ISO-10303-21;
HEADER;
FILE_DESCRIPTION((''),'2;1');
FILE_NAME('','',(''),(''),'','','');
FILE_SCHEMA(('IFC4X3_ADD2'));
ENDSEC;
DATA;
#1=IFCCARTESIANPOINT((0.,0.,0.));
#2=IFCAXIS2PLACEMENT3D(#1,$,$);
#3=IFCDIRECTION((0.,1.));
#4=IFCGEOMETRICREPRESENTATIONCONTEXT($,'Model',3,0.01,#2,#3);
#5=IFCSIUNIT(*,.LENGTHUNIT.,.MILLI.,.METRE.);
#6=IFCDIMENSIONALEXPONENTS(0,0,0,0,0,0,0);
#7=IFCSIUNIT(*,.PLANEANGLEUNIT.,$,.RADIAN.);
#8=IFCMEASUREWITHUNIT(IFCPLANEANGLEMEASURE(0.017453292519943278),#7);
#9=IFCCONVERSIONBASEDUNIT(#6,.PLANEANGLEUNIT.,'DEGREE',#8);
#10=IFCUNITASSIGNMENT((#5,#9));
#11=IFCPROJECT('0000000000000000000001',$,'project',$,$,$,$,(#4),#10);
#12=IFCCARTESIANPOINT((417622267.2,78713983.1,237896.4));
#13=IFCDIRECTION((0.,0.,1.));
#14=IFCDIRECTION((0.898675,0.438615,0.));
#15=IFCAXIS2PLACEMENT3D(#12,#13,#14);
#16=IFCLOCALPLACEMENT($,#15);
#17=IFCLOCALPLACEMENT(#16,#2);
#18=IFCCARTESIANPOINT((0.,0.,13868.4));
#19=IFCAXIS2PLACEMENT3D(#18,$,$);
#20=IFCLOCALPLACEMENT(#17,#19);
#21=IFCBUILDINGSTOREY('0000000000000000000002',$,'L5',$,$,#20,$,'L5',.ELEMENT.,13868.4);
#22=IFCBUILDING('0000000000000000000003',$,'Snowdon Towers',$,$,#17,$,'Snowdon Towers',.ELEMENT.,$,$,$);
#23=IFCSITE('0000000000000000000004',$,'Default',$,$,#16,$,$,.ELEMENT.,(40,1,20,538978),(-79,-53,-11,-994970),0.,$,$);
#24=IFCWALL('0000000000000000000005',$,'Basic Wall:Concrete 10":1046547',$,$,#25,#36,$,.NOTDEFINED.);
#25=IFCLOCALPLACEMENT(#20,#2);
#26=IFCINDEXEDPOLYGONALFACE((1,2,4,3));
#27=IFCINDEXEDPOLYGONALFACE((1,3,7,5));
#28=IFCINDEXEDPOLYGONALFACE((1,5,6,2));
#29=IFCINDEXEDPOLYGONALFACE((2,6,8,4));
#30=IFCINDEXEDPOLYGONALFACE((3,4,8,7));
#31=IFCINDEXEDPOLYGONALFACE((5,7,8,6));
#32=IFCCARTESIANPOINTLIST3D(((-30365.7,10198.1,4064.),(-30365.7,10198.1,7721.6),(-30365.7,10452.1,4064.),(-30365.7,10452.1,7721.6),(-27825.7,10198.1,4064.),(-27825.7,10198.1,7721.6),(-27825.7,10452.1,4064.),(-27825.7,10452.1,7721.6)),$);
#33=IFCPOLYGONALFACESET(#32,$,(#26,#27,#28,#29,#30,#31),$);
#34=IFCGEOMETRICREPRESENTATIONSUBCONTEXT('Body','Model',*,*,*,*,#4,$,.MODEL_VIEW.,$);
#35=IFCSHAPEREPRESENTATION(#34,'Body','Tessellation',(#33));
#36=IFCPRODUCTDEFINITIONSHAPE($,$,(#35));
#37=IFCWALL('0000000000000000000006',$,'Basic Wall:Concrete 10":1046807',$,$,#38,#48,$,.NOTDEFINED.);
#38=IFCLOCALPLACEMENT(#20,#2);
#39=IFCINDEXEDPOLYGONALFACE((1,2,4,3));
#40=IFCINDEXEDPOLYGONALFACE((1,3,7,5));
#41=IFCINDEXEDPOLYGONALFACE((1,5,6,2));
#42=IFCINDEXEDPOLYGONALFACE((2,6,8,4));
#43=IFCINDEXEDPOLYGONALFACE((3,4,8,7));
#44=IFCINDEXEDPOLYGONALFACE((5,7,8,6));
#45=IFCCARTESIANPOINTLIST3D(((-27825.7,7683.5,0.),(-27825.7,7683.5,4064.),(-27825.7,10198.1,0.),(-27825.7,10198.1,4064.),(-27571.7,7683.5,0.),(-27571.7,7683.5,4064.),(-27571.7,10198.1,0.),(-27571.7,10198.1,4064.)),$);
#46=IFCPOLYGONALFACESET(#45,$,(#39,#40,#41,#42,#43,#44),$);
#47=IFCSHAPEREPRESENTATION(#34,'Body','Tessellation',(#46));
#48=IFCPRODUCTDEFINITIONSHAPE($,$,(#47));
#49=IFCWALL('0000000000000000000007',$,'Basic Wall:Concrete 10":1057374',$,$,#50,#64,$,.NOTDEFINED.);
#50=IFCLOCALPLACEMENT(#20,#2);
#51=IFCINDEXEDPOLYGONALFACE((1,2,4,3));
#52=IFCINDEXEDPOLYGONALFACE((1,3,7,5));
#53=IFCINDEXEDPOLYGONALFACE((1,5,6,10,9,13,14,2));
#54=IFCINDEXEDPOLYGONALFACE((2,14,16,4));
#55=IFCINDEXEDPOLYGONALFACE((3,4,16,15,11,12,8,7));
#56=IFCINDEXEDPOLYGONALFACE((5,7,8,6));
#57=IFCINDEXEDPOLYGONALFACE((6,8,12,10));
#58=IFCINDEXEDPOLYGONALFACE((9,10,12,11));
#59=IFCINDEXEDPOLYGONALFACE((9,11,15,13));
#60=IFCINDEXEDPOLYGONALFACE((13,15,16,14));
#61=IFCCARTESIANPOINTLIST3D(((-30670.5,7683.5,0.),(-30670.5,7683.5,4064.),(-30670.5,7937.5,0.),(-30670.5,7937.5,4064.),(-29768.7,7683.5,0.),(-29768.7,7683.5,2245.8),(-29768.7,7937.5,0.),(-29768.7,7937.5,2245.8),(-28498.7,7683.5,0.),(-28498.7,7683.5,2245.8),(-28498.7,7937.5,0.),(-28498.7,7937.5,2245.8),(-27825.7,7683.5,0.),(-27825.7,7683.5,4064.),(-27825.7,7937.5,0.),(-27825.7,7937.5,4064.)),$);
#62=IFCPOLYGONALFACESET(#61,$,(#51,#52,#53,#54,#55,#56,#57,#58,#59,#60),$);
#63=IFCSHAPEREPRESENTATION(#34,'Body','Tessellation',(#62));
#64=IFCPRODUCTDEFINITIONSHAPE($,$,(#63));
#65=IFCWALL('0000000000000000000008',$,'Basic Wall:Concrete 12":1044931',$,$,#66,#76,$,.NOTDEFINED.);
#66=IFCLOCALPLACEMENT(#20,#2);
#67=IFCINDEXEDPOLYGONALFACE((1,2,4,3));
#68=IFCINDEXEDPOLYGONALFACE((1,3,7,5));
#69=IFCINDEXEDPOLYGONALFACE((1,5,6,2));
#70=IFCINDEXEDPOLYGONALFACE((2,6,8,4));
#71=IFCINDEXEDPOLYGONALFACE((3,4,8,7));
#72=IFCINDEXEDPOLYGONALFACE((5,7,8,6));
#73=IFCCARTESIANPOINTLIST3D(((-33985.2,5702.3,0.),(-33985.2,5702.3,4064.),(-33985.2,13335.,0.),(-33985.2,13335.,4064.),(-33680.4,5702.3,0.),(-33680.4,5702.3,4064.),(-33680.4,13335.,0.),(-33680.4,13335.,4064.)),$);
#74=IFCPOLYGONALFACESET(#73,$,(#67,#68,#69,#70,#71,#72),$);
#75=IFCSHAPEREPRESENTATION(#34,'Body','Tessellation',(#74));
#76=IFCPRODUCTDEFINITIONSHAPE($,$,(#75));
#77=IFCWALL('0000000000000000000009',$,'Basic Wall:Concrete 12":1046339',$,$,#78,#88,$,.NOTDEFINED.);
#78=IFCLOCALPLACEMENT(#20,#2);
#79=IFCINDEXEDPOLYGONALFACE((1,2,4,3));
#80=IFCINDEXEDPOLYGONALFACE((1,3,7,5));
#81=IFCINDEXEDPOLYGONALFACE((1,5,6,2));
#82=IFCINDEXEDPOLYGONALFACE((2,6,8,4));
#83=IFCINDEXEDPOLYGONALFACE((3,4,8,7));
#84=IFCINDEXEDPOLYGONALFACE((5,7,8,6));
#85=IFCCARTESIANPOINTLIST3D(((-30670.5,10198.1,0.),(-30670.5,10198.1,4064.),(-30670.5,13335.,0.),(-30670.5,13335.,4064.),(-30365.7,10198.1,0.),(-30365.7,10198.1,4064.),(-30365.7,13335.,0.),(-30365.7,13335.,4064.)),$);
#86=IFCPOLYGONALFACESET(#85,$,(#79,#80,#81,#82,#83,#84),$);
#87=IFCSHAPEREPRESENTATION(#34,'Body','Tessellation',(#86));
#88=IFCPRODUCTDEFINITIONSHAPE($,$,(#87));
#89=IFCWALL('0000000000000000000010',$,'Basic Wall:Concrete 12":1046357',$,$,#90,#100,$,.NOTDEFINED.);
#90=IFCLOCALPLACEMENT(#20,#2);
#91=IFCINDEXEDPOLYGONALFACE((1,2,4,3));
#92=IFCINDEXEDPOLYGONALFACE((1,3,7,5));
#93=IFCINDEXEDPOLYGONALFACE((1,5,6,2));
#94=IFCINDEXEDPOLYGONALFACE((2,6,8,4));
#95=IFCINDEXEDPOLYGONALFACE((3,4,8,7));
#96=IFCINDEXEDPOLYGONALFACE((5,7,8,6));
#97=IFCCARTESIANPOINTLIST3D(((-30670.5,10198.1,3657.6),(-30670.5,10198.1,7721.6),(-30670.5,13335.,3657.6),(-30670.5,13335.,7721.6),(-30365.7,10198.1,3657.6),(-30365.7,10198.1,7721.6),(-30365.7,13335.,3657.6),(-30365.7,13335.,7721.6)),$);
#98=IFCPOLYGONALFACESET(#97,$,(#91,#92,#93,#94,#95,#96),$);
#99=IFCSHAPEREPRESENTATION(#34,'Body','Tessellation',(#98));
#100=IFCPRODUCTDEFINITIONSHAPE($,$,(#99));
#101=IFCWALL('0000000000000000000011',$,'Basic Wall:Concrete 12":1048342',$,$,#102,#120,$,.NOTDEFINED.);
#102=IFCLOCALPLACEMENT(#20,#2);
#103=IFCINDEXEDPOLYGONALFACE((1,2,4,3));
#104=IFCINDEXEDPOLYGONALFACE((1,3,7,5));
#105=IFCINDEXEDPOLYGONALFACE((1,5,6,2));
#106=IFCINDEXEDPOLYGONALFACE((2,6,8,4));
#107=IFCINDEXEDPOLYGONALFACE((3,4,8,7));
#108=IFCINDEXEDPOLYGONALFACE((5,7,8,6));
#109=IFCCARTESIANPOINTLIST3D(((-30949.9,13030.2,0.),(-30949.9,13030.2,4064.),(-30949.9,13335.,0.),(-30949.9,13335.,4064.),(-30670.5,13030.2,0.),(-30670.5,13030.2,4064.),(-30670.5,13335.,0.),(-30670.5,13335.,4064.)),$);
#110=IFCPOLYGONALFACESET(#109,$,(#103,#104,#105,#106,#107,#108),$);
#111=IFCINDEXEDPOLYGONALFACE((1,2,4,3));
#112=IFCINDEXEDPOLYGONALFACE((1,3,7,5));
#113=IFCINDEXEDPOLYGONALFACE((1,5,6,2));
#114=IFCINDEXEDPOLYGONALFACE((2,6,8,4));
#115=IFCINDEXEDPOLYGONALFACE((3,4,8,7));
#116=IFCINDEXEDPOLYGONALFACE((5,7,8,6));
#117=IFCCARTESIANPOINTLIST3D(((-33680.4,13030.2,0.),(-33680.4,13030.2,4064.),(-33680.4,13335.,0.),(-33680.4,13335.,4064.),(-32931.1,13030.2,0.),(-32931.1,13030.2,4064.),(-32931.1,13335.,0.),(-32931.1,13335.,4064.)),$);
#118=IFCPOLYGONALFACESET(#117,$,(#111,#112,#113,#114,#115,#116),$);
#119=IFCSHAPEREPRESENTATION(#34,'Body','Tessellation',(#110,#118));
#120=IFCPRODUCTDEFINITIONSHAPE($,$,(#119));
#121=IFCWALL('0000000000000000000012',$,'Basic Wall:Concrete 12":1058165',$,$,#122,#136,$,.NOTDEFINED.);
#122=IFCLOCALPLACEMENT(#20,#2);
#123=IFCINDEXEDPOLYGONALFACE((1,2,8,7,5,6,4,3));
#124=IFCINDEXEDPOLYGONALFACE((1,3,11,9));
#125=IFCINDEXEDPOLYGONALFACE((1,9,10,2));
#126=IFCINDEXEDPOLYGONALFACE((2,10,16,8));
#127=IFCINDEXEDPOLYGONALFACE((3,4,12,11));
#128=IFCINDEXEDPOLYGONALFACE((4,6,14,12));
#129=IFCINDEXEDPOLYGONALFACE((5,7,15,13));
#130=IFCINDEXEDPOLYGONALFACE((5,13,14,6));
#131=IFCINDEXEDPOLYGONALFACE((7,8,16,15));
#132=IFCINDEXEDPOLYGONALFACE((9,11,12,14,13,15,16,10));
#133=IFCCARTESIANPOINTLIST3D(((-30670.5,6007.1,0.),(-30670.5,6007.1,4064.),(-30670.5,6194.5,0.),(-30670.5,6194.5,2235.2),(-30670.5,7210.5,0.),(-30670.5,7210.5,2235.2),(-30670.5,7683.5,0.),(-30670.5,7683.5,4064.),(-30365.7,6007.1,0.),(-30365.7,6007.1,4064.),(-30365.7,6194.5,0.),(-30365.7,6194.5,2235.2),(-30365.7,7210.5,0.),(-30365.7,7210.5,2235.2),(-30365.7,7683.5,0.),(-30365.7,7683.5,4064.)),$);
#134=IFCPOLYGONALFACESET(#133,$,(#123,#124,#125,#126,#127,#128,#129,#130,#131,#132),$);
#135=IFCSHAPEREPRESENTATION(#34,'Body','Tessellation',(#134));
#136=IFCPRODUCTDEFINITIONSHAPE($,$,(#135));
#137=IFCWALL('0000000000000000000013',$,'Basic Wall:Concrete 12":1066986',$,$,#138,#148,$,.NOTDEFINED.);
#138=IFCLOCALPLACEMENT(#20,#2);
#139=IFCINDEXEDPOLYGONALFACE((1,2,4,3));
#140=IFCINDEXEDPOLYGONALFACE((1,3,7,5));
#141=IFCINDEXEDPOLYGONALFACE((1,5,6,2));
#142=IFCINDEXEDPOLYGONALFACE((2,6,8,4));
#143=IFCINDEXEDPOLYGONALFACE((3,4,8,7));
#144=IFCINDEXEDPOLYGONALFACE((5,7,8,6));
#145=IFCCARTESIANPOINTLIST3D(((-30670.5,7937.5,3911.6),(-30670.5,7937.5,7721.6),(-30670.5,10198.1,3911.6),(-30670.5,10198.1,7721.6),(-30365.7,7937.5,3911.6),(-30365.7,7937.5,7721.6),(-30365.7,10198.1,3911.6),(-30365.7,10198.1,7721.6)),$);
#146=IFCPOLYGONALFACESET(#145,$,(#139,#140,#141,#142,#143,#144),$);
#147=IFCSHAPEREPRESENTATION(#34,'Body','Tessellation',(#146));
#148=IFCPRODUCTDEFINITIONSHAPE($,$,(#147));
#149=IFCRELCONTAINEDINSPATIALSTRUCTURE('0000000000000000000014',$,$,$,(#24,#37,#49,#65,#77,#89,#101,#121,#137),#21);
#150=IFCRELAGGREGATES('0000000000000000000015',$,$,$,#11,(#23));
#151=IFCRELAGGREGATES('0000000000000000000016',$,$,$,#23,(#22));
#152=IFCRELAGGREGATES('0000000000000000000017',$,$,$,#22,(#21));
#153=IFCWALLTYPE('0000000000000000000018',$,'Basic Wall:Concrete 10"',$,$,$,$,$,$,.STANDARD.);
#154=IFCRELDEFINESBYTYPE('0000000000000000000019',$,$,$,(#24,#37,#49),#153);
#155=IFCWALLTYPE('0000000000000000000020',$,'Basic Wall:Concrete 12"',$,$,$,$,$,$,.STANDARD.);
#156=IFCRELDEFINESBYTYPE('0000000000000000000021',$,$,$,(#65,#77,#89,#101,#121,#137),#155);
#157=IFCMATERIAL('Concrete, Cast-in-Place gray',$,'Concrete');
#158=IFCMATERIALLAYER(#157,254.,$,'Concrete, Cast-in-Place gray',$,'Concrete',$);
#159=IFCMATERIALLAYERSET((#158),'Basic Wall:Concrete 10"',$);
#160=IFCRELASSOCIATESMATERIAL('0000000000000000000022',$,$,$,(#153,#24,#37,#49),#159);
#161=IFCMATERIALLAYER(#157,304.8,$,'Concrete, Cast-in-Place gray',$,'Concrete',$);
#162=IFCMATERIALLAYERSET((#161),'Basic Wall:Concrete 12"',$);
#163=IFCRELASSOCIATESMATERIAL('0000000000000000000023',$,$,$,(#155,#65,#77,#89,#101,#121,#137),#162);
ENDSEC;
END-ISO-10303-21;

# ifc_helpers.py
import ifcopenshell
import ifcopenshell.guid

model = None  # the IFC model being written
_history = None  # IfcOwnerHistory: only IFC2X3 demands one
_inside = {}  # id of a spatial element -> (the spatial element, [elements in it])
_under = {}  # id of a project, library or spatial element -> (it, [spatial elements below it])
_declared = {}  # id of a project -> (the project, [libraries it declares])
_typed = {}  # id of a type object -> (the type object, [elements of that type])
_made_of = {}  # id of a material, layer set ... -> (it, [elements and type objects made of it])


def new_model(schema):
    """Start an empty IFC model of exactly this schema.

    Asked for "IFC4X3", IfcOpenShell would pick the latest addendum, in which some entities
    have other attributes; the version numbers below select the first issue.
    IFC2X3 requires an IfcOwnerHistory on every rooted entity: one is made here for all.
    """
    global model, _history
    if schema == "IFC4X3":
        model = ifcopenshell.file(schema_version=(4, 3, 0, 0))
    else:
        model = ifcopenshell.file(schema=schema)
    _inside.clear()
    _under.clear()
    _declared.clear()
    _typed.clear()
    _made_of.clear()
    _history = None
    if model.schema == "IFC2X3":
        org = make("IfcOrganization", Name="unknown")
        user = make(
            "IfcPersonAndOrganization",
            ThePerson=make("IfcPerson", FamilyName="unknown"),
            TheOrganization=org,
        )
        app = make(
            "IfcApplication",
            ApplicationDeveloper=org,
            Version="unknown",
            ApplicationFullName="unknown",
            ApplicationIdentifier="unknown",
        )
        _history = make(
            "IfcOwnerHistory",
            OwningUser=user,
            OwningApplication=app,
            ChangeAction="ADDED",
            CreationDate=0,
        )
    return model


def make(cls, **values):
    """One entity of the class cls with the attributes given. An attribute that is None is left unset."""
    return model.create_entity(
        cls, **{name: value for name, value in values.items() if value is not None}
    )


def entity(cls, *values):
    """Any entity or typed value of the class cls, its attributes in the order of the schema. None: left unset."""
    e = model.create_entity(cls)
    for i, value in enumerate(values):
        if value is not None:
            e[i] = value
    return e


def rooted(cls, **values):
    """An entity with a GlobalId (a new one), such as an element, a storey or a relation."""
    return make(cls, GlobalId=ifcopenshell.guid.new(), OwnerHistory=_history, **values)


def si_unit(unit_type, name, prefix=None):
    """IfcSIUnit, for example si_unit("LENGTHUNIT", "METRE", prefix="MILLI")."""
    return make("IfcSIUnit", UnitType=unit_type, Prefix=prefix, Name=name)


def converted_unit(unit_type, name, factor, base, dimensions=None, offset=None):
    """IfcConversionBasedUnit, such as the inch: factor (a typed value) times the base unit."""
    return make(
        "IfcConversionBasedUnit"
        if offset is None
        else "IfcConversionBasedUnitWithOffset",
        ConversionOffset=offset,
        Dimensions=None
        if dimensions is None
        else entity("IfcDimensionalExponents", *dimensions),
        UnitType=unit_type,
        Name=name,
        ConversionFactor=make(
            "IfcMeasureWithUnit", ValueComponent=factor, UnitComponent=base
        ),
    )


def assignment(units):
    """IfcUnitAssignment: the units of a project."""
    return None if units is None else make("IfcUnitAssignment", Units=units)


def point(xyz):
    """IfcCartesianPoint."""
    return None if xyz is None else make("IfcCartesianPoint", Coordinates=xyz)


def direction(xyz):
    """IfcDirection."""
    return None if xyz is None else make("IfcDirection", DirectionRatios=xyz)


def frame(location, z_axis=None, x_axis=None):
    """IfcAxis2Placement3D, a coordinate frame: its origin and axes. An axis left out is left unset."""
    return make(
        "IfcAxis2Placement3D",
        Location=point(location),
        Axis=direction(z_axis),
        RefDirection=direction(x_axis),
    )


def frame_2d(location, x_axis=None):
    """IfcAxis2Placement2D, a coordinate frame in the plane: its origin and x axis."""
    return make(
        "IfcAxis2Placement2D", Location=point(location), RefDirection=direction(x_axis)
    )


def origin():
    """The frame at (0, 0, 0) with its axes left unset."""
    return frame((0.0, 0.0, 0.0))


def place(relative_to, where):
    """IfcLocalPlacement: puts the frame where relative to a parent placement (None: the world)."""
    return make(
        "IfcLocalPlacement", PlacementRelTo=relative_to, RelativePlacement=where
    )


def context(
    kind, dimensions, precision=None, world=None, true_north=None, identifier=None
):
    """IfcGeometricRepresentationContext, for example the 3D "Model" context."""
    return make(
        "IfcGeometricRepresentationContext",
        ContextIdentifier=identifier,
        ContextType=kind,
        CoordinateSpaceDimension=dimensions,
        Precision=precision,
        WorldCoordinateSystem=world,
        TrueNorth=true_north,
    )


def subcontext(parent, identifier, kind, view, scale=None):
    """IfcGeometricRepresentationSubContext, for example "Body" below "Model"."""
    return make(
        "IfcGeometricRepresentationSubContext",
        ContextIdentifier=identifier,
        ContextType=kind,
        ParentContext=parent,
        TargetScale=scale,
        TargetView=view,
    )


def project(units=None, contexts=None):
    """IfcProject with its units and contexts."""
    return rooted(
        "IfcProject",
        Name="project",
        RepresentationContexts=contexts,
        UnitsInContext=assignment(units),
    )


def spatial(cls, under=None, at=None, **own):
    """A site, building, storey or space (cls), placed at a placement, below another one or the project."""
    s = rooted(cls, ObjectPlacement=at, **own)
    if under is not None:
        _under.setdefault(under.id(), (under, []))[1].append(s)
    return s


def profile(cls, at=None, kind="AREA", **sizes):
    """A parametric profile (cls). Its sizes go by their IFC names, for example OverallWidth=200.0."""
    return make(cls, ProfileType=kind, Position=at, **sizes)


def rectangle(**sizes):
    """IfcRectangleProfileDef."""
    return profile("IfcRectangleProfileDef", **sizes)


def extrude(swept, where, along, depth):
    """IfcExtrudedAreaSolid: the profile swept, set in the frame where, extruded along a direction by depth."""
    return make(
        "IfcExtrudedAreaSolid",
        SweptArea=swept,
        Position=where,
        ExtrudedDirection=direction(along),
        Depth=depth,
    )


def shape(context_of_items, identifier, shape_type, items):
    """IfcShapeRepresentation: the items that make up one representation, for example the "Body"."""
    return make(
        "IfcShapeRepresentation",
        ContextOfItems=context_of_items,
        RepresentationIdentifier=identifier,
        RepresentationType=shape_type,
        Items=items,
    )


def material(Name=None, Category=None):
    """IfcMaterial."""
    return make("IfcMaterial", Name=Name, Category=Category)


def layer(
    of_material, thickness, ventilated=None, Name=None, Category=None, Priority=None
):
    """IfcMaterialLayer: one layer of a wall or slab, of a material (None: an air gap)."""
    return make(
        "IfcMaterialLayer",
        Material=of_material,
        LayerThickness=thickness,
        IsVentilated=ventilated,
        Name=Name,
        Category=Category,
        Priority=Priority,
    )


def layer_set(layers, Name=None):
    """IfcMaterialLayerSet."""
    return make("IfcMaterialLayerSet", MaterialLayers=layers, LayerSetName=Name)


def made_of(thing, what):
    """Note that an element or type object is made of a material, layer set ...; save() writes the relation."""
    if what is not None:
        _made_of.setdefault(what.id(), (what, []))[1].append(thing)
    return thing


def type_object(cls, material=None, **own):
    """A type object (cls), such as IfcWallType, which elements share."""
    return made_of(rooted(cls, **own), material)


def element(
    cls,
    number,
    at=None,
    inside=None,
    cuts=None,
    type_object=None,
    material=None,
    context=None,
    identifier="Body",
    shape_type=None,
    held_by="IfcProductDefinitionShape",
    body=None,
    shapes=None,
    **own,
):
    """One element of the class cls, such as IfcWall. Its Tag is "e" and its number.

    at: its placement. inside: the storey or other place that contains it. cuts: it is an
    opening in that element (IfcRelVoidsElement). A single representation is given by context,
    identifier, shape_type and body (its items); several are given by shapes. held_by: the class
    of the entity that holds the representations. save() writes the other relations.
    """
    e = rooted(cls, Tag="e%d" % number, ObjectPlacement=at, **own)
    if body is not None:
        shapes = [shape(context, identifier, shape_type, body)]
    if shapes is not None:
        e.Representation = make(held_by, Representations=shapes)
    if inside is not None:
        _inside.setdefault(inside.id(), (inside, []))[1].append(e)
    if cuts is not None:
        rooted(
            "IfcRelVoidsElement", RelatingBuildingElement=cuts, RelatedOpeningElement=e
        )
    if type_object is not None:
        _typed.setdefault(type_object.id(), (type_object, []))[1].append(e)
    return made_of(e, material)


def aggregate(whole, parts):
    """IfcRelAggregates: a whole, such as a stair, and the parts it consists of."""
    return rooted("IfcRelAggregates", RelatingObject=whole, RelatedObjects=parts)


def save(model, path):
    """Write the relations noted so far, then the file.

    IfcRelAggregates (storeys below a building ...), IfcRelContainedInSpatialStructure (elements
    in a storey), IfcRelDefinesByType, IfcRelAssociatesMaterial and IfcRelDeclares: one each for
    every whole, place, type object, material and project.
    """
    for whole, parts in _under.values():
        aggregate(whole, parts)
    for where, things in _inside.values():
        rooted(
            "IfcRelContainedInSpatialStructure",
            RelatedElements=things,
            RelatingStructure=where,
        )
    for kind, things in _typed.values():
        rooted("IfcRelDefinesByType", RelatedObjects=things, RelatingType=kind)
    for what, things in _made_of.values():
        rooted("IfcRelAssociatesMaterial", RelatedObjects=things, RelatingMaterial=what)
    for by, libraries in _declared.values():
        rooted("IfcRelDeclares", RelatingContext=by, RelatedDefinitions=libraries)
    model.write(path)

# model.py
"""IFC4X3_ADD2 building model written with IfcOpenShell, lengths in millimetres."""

from ifc_helpers import new_model, entity, si_unit, converted_unit, direction, frame, frame_2d, origin, place, context, subcontext, project, spatial, rectangle, extrude, material, layer, layer_set, type_object, element, save


model = new_model("IFC4X3_ADD2")

# Units and contexts
model_context = context("Model", 3, precision=0.01, world=origin(), true_north=direction((0.0, 1.0)))
body_context = subcontext(model_context, "Body", "Model", "MODEL_VIEW")
ifc_project = project(units=[si_unit("LENGTHUNIT", "METRE", prefix="MILLI"), converted_unit("PLANEANGLEUNIT", "DEGREE", entity("IfcPlaneAngleMeasure", 0.017453292519943278), si_unit("PLANEANGLEUNIT", "RADIAN"), dimensions=[0, 0, 0, 0, 0, 0, 0])], contexts=[model_context])

# Site, building, storey
site_placement = place(None, frame((417622267.2, 78713983.1, 237896.4), z_axis=(0.0, 0.0, 1.0), x_axis=(0.898675, 0.438615, 0.0)))
site = spatial("IfcSite", under=ifc_project, at=site_placement, Name="Default", CompositionType="ELEMENT", RefLatitude=(40, 1, 20, 538978), RefLongitude=(-79, -53, -11, -994970), RefElevation=0.0)
building_placement = place(site_placement, origin())
building = spatial("IfcBuilding", under=site, at=building_placement, Name="Snowdon Towers", LongName="Snowdon Towers", CompositionType="ELEMENT")
storey_placement = place(building_placement, frame((0.0, 0.0, 13868.4)))
storey = spatial("IfcBuildingStorey", under=building, at=storey_placement, Name="L5", LongName="L5", CompositionType="ELEMENT", Elevation=13868.4)

# Walls
ifc_material_1 = material(Name="Concrete, Cast-in-Place gray", Category="Concrete")
ifc_layer_1 = layer(ifc_material_1, 254.0, Name="Concrete, Cast-in-Place gray", Category="Concrete")
ifc_layer_set_1 = layer_set([ifc_layer_1], Name="Basic Wall:Concrete 10\"")
wall_type_1 = type_object("IfcWallType", Name="Basic Wall:Concrete 10\"", PredefinedType="STANDARD", material=ifc_layer_set_1)
wall_1_placement = place(storey_placement, frame((-30365.7, 10325.1, 4064.0)))
element("IfcWall", 1, at=wall_1_placement, inside=storey, type_object=wall_type_1, material=ifc_layer_set_1, Name="Basic Wall:Concrete 10\":1046547", PredefinedType="NOTDEFINED", context=body_context, shape_type="SweptSolid", body=[
    extrude(rectangle(XDim=2540.0, YDim=254.0, at=frame_2d((1270.0, 0.0), x_axis=(-1.0, 0.0))), origin(), (0.0, 0.0, 1.0), 3657.6),
])
wall_2_placement = place(storey_placement, frame((-27698.7, 10198.1, 0.0), z_axis=(0.0, 0.0, 1.0), x_axis=(0.0, -1.0, 0.0)))
element("IfcWall", 2, at=wall_2_placement, inside=storey, type_object=wall_type_1, material=ifc_layer_set_1, Name="Basic Wall:Concrete 10\":1046807", PredefinedType="NOTDEFINED", context=body_context, shape_type="SweptSolid", body=[
    extrude(rectangle(XDim=2514.6, YDim=254.0, at=frame_2d((1257.3, 0.0), x_axis=(-1.0, 0.0))), origin(), (0.0, 0.0, 1.0), 4064.0),
])

# Wall, opening
wall_3_placement = place(storey_placement, frame((-27825.7, 7810.5, 0.0), z_axis=(0.0, 0.0, 1.0), x_axis=(-1.0, 0.0, 0.0)))
wall_3 = element("IfcWall", 3, at=wall_3_placement, inside=storey, type_object=wall_type_1, material=ifc_layer_set_1, Name="Basic Wall:Concrete 10\":1057374", PredefinedType="NOTDEFINED", context=body_context, shape_type="SweptSolid", body=[
    extrude(rectangle(XDim=2844.8, YDim=254.0, at=frame_2d((1422.4, 0.0), x_axis=(-1.0, 0.0))), origin(), (0.0, 0.0, 1.0), 4064.0),
])
opening_1_placement = place(wall_3_placement, origin())
element("IfcOpeningElement", 4, at=opening_1_placement, cuts=wall_3, PredefinedType="OPENING", context=body_context, shape_type="SweptSolid", body=[
    extrude(rectangle(XDim=2245.8, YDim=1270.0, at=frame_2d((0.0, 0.0), x_axis=(0.0, 1.0))), frame((1308.0, 127.0, 1122.9), z_axis=(0.0, -1.0, 0.0), x_axis=(1.0, 0.0, 0.0)), (0.0, 0.0, 1.0), 254.0),
])

# Walls
ifc_layer_2 = layer(ifc_material_1, 304.8, Name="Concrete, Cast-in-Place gray", Category="Concrete")
ifc_layer_set_2 = layer_set([ifc_layer_2], Name="Basic Wall:Concrete 12\"")
wall_type_2 = type_object("IfcWallType", Name="Basic Wall:Concrete 12\"", PredefinedType="STANDARD", material=ifc_layer_set_2)
wall_4_placement = place(storey_placement, frame((-33832.8, 13335.0, 0.0), z_axis=(0.0, 0.0, 1.0), x_axis=(0.0, -1.0, 0.0)))
element("IfcWall", 5, at=wall_4_placement, inside=storey, type_object=wall_type_2, material=ifc_layer_set_2, Name="Basic Wall:Concrete 12\":1044931", PredefinedType="NOTDEFINED", context=body_context, shape_type="SweptSolid", body=[
    extrude(rectangle(XDim=7632.7, YDim=304.8, at=frame_2d((3816.4, 0.0), x_axis=(-1.0, 0.0))), origin(), (0.0, 0.0, 1.0), 4064.0),
])
wall_5_placement = place(storey_placement, frame((-30518.1, 10198.1, 0.0), z_axis=(0.0, 0.0, 1.0), x_axis=(0.0, 1.0, 0.0)))
element("IfcWall", 6, at=wall_5_placement, inside=storey, type_object=wall_type_2, material=ifc_layer_set_2, Name="Basic Wall:Concrete 12\":1046339", PredefinedType="NOTDEFINED", context=body_context, shape_type="SweptSolid", body=[
    extrude(rectangle(XDim=3136.9, YDim=304.8, at=frame_2d((1568.5, 0.0), x_axis=(-1.0, 0.0))), origin(), (0.0, 0.0, 1.0), 4064.0),
])
wall_6_placement = place(storey_placement, frame((-30518.1, 10198.1, 3657.6), z_axis=(0.0, 0.0, 1.0), x_axis=(0.0, 1.0, 0.0)))
element("IfcWall", 7, at=wall_6_placement, inside=storey, type_object=wall_type_2, material=ifc_layer_set_2, Name="Basic Wall:Concrete 12\":1046357", PredefinedType="NOTDEFINED", context=body_context, shape_type="SweptSolid", body=[
    extrude(rectangle(XDim=3136.9, YDim=304.8, at=frame_2d((1568.5, 0.0), x_axis=(-1.0, 0.0))), origin(), (0.0, 0.0, 1.0), 4064.0),
])
wall_7_placement = place(storey_placement, frame((-30670.5, 13182.6, 0.0), z_axis=(0.0, 0.0, 1.0), x_axis=(-1.0, 0.0, 0.0)))
element("IfcWall", 8, at=wall_7_placement, inside=storey, type_object=wall_type_2, material=ifc_layer_set_2, Name="Basic Wall:Concrete 12\":1048342", PredefinedType="NOTDEFINED", context=body_context, shape_type="SweptSolid", body=[
    extrude(rectangle(XDim=304.8, YDim=279.4, at=frame_2d((0.0, 0.0), x_axis=(1.0, 0.0))), frame((139.7, 0.0, 0.0), z_axis=(0.0, 0.0, 1.0), x_axis=(0.0, 1.0, 0.0)), (0.0, 0.0, 1.0), 4064.0),
    extrude(rectangle(XDim=304.8, YDim=749.3, at=frame_2d((0.0, 0.0), x_axis=(1.0, 0.0))), frame((2635.3, 0.0, 0.0), z_axis=(0.0, 0.0, 1.0), x_axis=(0.0, 1.0, 0.0)), (0.0, 0.0, 1.0), 4064.0),
])

# Wall, opening
wall_8_placement = place(storey_placement, frame((-30518.1, 7683.5, 0.0), z_axis=(0.0, 0.0, 1.0), x_axis=(0.0, -1.0, 0.0)))
wall_8 = element("IfcWall", 9, at=wall_8_placement, inside=storey, type_object=wall_type_2, material=ifc_layer_set_2, Name="Basic Wall:Concrete 12\":1058165", PredefinedType="NOTDEFINED", context=body_context, shape_type="SweptSolid", body=[
    extrude(rectangle(XDim=1676.4, YDim=304.8, at=frame_2d((838.2, 0.0), x_axis=(-1.0, 0.0))), origin(), (0.0, 0.0, 1.0), 4064.0),
])
opening_2_placement = place(wall_8_placement, origin())
element("IfcOpeningElement", 10, at=opening_2_placement, cuts=wall_8, PredefinedType="OPENING", context=body_context, shape_type="SweptSolid", body=[
    extrude(rectangle(XDim=2235.2, YDim=1016.0, at=frame_2d((0.0, 0.0), x_axis=(0.0, 1.0))), frame((981.0, 152.4, 1117.6), z_axis=(0.0, -1.0, 0.0), x_axis=(1.0, 0.0, 0.0)), (0.0, 0.0, 1.0), 304.8),
])

# Wall
wall_9_placement = place(storey_placement, frame((-30518.1, 7937.5, 3911.6), z_axis=(0.0, 0.0, 1.0), x_axis=(0.0, 1.0, 0.0)))
element("IfcWall", 11, at=wall_9_placement, inside=storey, type_object=wall_type_2, material=ifc_layer_set_2, Name="Basic Wall:Concrete 12\":1066986", PredefinedType="NOTDEFINED", context=body_context, shape_type="SweptSolid", body=[
    extrude(rectangle(XDim=2260.6, YDim=304.8, at=frame_2d((1130.3, 0.0), x_axis=(-1.0, 0.0))), origin(), (0.0, 0.0, 1.0), 3810.0),
])

save(model, "model.ifc")
